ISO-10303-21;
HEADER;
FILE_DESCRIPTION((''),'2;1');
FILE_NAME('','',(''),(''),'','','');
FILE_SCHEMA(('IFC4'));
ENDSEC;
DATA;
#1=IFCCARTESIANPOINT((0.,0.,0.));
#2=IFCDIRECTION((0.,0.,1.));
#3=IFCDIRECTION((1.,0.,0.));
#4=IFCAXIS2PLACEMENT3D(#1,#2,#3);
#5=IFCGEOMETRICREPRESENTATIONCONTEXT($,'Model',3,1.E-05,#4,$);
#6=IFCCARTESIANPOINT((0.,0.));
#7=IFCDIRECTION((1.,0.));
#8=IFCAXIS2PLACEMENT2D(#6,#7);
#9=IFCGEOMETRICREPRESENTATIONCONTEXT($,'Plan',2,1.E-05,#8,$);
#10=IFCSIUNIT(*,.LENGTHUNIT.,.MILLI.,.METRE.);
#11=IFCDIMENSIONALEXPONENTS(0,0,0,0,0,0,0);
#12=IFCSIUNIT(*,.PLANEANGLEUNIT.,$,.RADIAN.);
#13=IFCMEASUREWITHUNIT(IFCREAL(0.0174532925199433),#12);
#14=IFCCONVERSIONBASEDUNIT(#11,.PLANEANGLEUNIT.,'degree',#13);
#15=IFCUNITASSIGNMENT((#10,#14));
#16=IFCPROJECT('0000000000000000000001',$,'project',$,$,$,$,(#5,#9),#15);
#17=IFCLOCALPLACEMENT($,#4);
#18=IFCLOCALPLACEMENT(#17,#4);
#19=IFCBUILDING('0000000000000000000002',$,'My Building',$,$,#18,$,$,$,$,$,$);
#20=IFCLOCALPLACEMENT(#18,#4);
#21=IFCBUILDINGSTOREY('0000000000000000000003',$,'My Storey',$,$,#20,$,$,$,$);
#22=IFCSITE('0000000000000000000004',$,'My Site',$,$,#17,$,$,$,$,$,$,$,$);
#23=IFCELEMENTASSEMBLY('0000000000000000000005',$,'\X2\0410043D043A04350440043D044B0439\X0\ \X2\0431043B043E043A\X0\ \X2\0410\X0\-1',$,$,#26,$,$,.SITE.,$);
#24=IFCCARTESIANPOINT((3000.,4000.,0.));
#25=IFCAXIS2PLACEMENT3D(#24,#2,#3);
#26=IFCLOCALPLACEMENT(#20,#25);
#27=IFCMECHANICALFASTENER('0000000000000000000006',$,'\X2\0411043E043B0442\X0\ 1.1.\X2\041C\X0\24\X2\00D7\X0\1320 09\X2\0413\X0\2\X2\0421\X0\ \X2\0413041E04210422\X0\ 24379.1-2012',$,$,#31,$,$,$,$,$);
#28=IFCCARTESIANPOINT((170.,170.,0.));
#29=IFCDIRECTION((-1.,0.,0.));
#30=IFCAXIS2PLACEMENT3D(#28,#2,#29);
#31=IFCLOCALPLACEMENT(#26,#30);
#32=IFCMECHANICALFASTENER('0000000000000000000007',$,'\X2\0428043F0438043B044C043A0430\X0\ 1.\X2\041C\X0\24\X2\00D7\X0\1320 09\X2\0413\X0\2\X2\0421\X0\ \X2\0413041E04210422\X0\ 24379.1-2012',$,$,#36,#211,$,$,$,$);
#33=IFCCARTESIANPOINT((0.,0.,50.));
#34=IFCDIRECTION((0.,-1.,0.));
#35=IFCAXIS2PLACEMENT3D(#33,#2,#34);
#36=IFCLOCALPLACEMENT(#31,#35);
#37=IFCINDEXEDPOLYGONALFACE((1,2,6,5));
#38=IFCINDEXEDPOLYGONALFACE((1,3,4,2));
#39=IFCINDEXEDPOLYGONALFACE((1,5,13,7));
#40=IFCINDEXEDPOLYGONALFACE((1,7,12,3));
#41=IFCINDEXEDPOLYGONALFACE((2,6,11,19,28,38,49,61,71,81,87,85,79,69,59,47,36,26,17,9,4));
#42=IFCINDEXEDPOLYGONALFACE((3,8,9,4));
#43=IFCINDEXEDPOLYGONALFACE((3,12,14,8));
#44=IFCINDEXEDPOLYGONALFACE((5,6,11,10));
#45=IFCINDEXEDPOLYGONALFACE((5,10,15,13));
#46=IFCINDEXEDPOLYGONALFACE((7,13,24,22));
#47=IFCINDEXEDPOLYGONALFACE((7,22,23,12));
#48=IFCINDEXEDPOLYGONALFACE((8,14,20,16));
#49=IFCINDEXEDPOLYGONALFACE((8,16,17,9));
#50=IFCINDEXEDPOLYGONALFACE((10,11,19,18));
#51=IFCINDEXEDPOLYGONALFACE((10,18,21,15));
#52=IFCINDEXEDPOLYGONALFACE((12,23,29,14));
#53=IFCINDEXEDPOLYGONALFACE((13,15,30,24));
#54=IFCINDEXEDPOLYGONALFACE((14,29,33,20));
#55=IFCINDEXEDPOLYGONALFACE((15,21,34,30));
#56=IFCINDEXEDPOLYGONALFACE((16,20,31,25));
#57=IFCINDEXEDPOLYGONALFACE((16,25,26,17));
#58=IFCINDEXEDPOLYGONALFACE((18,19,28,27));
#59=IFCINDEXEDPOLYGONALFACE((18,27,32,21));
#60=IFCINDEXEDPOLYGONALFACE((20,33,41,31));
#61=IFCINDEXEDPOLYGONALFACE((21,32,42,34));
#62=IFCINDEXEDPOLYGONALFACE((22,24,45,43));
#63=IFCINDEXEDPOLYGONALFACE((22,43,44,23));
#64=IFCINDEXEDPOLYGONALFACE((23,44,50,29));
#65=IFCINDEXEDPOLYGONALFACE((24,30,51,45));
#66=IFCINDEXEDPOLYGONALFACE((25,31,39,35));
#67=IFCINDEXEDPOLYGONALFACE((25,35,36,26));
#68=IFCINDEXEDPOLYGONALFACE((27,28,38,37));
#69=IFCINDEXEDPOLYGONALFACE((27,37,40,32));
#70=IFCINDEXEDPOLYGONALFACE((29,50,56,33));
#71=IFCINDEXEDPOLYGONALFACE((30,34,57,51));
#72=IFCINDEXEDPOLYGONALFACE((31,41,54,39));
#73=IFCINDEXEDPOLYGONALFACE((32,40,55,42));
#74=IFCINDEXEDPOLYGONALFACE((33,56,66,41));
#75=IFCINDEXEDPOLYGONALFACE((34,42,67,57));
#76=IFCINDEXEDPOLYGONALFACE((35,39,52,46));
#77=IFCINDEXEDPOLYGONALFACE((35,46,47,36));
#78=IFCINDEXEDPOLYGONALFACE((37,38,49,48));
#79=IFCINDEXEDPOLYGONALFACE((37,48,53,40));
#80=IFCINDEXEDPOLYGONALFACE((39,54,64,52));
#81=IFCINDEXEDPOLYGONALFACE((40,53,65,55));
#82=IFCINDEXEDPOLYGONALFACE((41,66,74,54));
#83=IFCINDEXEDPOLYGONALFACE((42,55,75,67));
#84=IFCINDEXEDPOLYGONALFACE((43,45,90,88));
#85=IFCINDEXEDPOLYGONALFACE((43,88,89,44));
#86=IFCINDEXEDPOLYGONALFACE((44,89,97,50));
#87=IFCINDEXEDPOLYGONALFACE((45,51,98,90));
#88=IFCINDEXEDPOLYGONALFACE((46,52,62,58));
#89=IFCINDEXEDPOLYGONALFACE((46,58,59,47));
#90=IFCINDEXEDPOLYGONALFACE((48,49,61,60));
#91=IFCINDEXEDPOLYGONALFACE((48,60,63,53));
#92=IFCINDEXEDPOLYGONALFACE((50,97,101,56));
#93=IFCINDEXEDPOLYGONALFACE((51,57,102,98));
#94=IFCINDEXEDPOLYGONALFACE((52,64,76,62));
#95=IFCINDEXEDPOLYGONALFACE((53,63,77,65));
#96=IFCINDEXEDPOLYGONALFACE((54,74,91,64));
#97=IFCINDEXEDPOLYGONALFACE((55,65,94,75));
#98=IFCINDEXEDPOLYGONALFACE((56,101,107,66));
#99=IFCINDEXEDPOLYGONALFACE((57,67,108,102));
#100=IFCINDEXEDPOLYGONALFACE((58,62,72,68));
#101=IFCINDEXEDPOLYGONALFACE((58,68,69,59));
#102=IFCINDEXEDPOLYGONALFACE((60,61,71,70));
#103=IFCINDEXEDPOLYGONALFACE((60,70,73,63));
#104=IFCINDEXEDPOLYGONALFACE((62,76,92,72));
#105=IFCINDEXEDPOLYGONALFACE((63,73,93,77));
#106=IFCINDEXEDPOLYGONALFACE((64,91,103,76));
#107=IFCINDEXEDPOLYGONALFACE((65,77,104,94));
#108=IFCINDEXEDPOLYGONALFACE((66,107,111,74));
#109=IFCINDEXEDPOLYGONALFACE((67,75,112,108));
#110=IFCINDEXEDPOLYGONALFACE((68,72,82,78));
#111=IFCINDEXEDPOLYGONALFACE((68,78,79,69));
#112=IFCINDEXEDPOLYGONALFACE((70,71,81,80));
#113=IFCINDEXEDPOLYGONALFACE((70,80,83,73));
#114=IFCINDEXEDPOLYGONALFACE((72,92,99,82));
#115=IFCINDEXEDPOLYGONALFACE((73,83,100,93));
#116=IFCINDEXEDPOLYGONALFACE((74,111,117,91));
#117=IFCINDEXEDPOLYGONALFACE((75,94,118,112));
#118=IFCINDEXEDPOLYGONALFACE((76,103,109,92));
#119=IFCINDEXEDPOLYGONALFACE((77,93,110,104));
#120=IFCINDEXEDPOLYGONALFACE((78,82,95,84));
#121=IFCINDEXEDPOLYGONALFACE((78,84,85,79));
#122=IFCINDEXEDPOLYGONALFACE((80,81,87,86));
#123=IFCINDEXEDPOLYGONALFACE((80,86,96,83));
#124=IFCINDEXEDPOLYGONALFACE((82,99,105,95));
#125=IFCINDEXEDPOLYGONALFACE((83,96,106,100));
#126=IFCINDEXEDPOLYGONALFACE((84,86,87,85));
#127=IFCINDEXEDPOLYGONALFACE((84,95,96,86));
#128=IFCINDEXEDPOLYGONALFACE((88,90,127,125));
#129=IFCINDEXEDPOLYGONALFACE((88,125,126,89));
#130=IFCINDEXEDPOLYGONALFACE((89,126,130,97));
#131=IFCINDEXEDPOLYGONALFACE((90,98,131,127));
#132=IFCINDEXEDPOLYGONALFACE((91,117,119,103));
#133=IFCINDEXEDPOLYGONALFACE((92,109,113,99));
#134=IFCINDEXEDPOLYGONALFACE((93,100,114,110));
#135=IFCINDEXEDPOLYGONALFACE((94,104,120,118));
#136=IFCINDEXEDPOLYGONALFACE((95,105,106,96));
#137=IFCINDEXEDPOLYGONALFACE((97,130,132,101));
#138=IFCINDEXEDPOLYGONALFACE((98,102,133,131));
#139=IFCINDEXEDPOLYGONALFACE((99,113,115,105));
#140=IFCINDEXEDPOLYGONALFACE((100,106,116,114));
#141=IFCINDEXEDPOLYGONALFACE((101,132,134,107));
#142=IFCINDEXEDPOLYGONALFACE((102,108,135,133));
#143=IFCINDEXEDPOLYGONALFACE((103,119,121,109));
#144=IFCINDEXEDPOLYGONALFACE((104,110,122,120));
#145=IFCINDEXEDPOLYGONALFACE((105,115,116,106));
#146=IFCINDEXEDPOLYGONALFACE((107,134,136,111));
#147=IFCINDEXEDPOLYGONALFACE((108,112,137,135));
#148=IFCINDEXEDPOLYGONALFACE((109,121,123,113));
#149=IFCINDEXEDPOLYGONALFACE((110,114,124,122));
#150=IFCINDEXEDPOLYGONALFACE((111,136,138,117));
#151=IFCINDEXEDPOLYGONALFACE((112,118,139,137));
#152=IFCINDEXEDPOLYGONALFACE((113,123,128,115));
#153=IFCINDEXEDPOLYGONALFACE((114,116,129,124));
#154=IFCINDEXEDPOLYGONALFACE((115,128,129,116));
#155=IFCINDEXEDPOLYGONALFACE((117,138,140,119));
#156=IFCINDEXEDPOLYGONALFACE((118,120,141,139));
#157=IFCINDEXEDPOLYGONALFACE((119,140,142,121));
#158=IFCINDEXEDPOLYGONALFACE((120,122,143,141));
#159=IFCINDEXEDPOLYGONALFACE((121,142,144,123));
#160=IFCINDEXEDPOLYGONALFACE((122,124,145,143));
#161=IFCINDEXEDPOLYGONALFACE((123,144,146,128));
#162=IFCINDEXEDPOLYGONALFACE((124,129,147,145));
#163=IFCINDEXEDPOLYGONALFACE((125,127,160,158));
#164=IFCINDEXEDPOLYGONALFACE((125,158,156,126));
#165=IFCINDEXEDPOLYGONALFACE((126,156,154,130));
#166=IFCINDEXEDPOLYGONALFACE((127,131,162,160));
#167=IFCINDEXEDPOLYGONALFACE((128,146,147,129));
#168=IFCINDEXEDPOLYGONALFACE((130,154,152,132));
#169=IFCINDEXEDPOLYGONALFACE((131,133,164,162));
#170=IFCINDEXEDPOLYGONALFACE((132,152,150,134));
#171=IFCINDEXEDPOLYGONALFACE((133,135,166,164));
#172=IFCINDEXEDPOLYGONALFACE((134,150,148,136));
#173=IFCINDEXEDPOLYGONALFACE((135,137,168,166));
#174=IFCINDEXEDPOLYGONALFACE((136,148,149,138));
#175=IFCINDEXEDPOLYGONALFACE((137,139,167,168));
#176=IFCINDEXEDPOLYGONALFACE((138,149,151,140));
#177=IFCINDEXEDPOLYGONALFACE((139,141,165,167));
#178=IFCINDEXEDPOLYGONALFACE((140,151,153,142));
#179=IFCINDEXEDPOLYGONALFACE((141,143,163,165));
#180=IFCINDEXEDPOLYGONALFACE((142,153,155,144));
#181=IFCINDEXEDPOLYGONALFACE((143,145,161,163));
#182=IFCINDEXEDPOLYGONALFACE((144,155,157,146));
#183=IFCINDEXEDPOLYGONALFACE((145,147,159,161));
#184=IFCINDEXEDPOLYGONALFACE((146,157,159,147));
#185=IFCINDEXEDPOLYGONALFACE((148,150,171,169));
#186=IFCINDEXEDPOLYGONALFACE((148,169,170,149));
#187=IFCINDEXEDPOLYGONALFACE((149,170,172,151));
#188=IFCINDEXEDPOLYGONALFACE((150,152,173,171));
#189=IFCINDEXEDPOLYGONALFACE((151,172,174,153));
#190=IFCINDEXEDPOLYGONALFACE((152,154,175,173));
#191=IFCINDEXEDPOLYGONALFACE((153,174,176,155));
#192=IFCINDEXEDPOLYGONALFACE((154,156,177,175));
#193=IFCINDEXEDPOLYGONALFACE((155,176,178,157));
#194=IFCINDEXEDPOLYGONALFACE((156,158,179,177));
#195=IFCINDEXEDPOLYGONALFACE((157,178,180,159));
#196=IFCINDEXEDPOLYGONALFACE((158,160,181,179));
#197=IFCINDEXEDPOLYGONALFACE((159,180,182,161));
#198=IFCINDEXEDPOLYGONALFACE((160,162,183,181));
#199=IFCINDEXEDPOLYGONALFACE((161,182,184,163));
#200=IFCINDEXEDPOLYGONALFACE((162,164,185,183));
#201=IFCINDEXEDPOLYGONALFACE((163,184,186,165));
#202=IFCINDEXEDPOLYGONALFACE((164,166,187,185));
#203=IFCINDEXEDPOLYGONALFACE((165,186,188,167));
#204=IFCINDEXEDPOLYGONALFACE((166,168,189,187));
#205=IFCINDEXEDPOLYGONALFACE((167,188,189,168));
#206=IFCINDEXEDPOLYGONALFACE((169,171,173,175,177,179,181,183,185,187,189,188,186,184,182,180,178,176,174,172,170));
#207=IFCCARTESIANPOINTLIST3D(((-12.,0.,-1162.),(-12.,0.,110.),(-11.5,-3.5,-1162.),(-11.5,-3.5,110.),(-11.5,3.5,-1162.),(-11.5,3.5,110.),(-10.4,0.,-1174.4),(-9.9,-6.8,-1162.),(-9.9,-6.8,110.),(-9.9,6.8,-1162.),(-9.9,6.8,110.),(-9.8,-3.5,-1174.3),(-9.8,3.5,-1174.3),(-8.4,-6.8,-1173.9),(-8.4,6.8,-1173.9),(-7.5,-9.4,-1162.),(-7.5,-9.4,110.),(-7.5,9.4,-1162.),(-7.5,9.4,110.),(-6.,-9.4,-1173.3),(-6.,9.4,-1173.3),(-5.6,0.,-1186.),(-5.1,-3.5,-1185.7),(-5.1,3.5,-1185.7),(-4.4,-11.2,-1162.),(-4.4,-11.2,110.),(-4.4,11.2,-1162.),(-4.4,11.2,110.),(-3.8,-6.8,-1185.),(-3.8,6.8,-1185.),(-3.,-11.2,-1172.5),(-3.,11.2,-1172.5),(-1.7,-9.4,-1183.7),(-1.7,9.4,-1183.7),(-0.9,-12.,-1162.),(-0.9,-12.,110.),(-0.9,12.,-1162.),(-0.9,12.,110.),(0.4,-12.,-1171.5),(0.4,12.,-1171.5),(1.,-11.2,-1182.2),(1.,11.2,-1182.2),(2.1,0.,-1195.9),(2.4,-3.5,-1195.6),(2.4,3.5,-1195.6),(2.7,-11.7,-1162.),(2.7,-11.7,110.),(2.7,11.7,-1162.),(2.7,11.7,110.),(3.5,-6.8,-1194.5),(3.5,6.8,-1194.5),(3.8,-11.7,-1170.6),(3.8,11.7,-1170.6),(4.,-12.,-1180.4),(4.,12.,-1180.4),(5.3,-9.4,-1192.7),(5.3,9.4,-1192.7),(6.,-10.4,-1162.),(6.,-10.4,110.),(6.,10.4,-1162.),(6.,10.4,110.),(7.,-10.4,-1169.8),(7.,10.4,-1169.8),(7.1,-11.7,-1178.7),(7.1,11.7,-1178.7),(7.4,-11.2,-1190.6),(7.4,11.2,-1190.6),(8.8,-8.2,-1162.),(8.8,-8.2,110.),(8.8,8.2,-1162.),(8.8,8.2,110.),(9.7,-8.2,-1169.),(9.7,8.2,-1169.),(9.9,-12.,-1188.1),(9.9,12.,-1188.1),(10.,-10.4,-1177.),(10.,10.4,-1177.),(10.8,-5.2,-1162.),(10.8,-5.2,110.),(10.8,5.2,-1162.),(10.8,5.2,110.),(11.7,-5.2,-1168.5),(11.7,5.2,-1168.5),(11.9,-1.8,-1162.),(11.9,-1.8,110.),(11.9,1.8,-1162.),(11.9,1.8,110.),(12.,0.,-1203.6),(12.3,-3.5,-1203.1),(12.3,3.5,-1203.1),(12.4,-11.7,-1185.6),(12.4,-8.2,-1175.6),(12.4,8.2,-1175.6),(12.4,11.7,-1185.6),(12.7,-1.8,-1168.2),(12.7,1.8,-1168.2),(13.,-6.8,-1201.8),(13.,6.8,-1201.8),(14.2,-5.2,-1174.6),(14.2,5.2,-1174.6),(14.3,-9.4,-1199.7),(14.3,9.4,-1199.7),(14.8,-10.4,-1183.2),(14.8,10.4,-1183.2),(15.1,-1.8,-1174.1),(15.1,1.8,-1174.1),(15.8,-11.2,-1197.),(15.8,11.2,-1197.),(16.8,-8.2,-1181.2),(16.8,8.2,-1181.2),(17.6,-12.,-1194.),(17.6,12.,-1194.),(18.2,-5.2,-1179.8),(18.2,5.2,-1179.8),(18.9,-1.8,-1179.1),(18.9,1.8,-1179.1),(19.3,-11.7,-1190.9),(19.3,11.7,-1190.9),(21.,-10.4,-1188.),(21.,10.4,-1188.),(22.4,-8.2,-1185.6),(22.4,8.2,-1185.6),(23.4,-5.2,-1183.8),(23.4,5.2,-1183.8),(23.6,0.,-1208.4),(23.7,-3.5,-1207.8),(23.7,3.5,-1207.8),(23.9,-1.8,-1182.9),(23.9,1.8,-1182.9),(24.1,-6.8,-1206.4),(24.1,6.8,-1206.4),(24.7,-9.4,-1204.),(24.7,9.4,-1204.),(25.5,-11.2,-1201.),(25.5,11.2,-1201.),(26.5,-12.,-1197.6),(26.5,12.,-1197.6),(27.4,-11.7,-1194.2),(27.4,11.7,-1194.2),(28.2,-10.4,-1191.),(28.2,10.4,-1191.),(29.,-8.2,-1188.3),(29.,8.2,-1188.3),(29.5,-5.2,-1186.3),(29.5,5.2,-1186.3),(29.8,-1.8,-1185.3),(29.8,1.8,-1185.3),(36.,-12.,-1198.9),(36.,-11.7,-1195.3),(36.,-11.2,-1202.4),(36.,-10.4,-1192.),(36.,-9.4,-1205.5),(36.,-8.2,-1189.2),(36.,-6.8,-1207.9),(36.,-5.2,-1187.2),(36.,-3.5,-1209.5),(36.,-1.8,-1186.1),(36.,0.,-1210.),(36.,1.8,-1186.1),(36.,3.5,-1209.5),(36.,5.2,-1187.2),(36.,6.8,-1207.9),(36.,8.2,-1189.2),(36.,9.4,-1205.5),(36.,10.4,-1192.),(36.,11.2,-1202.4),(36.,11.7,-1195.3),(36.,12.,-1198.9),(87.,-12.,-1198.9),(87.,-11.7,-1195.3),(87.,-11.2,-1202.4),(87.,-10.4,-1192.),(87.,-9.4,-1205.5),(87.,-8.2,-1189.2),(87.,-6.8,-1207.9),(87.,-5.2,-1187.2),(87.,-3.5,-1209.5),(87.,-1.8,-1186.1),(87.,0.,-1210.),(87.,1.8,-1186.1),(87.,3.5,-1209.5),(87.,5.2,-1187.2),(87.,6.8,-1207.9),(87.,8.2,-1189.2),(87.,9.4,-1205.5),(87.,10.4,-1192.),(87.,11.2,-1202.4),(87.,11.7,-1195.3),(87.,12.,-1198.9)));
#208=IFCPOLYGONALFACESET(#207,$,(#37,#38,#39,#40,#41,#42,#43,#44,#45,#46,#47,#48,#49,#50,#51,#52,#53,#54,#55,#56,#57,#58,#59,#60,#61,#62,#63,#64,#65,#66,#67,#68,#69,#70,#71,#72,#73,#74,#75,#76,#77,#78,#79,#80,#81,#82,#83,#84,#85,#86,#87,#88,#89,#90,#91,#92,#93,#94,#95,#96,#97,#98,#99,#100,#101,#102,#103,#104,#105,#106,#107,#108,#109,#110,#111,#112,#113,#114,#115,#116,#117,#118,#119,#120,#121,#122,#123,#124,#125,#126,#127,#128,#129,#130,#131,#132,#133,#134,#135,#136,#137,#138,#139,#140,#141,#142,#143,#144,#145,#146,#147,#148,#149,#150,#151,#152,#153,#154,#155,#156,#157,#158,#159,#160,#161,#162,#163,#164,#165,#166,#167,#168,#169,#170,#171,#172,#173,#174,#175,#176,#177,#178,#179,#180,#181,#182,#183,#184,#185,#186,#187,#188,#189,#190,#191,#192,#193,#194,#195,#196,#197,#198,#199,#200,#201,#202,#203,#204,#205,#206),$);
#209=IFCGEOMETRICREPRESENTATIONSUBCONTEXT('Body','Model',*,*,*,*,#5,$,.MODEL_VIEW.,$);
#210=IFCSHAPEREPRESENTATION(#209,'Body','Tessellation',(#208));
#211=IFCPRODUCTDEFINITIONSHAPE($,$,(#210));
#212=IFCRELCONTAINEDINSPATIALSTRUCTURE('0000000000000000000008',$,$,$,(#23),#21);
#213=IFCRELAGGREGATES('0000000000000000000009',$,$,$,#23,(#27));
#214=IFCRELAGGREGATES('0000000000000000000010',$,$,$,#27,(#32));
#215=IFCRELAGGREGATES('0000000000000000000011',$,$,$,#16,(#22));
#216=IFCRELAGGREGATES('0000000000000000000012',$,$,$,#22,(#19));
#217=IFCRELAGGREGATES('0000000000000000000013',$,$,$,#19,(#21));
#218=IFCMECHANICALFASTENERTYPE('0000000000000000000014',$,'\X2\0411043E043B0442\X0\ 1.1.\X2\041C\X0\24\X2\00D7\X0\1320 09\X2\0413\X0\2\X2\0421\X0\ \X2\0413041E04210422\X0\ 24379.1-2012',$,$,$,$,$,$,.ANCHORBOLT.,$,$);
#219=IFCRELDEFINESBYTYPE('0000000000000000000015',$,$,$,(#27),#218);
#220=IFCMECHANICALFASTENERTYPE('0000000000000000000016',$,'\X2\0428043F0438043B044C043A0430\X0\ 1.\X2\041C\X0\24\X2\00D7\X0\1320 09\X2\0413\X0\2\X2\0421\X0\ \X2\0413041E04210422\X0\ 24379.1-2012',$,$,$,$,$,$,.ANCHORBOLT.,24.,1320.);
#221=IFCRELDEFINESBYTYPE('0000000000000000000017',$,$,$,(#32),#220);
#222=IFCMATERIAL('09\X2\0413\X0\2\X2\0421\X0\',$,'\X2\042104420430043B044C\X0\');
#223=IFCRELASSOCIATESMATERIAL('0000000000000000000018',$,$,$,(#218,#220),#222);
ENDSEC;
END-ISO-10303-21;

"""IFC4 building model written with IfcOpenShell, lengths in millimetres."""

from ifc_helpers import new_model, entity, si_unit, converted_unit, frame, origin_with_axes, origin_2d_with_axis, place, context, subcontext, project, spatial, source, transform, mapped, material, type_object, type_shapes, element, aggregate, save


model = new_model("IFC4")

# Units and contexts
model_context = context("Model", 3, precision=1e-05, world=origin_with_axes())
plan_context = context("Plan", 2, precision=1e-05, world=origin_2d_with_axis())
body_context = subcontext(model_context, "Body", "Model", "MODEL_VIEW")
ifc_project = project(units=[si_unit("LENGTHUNIT", "METRE", prefix="MILLI"), converted_unit("PLANEANGLEUNIT", "degree", entity("IfcReal", 0.0174532925199433), si_unit("PLANEANGLEUNIT", "RADIAN"), dimensions=[0, 0, 0, 0, 0, 0, 0])], contexts=[model_context, plan_context])

# Site, building, storey
site_placement = place(None, origin_with_axes())
site = spatial("IfcSite", under=ifc_project, at=site_placement, Name="My Site")
building_placement = place(site_placement, origin_with_axes())
building = spatial("IfcBuilding", under=site, at=building_placement, Name="My Building")
storey_placement = place(building_placement, origin_with_axes())
storey = spatial("IfcBuildingStorey", under=building, at=storey_placement, Name="My Storey")

# Element assembly, mechanical fasteners
ifc_material_1 = material(Name="09Г2С", Category="Сталь")
mechanical_fastener_type_1 = type_object("IfcMechanicalFastenerType", Name="Болт 1.1.М24×1320 09Г2С ГОСТ 24379.1-2012", PredefinedType="ANCHORBOLT", material=ifc_material_1)
mechanical_fastener_type_2 = type_object("IfcMechanicalFastenerType", Name="Шпилька 1.М24×1320 09Г2С ГОСТ 24379.1-2012", NominalDiameter=24.0, NominalLength=1320.0, PredefinedType="ANCHORBOLT", material=ifc_material_1)
shared_shape_1 = source(frame((0.0, 0.0, 110.0), z_axis=(0.0, 0.0, 1.0), x_axis=(1.0, 0.0, 0.0)), body_context, "Body", "AdvancedSweptSolid", [
    entity("IfcSweptDiskSolid", entity("IfcIndexedPolyCurve", entity("IfcCartesianPointList3D", [[0.0, 0.0, 0.0], [0.0, 0.0, -1272.0], [10.5, 0.0, -1297.5], [36.0, 0.0, -1308.0], [87.0, 0.0, -1308.0]]), [entity("IfcLineIndex", [1, 2]), entity("IfcArcIndex", [2, 3, 4]), entity("IfcLineIndex", [4, 5])]), 12.0),
])
type_shapes(mechanical_fastener_type_2, [shared_shape_1])
assembly_1_placement = place(storey_placement, frame((3000.0, 4000.0, 0.0), z_axis=(0.0, 0.0, 1.0), x_axis=(1.0, 0.0, 0.0)))
assembly_1 = element("IfcElementAssembly", 1, at=assembly_1_placement, inside=storey, Name="Анкерный блок А-1", AssemblyPlace="SITE")
mechanical_fastener_1_placement = place(assembly_1_placement, frame((170.0, 170.0, 0.0), z_axis=(0.0, 0.0, 1.0), x_axis=(-1.0, 0.0, 0.0)))
mechanical_fastener_1 = element("IfcMechanicalFastener", 2, at=mechanical_fastener_1_placement, type_object=mechanical_fastener_type_1, Name="Болт 1.1.М24×1320 09Г2С ГОСТ 24379.1-2012")
mechanical_fastener_2_placement = place(mechanical_fastener_1_placement, frame((0.0, 0.0, 50.0), z_axis=(0.0, 0.0, 1.0), x_axis=(0.0, -1.0, 0.0)))
mechanical_fastener_2 = element("IfcMechanicalFastener", 3, at=mechanical_fastener_2_placement, type_object=mechanical_fastener_type_2, Name="Шпилька 1.М24×1320 09Г2С ГОСТ 24379.1-2012", context=body_context, shape_type="MappedRepresentation", body=[
    mapped(shared_shape_1, transform((0.0, 0.0, 0.0), x_axis=(1.0, 0.0, 0.0), y_axis=(0.0, 1.0, 0.0), z_axis=(0.0, 0.0, 1.0), scale=1.0)),
])
aggregate(assembly_1, [mechanical_fastener_1])

aggregate(mechanical_fastener_1, [mechanical_fastener_2])

save(model, "model.ifc")
